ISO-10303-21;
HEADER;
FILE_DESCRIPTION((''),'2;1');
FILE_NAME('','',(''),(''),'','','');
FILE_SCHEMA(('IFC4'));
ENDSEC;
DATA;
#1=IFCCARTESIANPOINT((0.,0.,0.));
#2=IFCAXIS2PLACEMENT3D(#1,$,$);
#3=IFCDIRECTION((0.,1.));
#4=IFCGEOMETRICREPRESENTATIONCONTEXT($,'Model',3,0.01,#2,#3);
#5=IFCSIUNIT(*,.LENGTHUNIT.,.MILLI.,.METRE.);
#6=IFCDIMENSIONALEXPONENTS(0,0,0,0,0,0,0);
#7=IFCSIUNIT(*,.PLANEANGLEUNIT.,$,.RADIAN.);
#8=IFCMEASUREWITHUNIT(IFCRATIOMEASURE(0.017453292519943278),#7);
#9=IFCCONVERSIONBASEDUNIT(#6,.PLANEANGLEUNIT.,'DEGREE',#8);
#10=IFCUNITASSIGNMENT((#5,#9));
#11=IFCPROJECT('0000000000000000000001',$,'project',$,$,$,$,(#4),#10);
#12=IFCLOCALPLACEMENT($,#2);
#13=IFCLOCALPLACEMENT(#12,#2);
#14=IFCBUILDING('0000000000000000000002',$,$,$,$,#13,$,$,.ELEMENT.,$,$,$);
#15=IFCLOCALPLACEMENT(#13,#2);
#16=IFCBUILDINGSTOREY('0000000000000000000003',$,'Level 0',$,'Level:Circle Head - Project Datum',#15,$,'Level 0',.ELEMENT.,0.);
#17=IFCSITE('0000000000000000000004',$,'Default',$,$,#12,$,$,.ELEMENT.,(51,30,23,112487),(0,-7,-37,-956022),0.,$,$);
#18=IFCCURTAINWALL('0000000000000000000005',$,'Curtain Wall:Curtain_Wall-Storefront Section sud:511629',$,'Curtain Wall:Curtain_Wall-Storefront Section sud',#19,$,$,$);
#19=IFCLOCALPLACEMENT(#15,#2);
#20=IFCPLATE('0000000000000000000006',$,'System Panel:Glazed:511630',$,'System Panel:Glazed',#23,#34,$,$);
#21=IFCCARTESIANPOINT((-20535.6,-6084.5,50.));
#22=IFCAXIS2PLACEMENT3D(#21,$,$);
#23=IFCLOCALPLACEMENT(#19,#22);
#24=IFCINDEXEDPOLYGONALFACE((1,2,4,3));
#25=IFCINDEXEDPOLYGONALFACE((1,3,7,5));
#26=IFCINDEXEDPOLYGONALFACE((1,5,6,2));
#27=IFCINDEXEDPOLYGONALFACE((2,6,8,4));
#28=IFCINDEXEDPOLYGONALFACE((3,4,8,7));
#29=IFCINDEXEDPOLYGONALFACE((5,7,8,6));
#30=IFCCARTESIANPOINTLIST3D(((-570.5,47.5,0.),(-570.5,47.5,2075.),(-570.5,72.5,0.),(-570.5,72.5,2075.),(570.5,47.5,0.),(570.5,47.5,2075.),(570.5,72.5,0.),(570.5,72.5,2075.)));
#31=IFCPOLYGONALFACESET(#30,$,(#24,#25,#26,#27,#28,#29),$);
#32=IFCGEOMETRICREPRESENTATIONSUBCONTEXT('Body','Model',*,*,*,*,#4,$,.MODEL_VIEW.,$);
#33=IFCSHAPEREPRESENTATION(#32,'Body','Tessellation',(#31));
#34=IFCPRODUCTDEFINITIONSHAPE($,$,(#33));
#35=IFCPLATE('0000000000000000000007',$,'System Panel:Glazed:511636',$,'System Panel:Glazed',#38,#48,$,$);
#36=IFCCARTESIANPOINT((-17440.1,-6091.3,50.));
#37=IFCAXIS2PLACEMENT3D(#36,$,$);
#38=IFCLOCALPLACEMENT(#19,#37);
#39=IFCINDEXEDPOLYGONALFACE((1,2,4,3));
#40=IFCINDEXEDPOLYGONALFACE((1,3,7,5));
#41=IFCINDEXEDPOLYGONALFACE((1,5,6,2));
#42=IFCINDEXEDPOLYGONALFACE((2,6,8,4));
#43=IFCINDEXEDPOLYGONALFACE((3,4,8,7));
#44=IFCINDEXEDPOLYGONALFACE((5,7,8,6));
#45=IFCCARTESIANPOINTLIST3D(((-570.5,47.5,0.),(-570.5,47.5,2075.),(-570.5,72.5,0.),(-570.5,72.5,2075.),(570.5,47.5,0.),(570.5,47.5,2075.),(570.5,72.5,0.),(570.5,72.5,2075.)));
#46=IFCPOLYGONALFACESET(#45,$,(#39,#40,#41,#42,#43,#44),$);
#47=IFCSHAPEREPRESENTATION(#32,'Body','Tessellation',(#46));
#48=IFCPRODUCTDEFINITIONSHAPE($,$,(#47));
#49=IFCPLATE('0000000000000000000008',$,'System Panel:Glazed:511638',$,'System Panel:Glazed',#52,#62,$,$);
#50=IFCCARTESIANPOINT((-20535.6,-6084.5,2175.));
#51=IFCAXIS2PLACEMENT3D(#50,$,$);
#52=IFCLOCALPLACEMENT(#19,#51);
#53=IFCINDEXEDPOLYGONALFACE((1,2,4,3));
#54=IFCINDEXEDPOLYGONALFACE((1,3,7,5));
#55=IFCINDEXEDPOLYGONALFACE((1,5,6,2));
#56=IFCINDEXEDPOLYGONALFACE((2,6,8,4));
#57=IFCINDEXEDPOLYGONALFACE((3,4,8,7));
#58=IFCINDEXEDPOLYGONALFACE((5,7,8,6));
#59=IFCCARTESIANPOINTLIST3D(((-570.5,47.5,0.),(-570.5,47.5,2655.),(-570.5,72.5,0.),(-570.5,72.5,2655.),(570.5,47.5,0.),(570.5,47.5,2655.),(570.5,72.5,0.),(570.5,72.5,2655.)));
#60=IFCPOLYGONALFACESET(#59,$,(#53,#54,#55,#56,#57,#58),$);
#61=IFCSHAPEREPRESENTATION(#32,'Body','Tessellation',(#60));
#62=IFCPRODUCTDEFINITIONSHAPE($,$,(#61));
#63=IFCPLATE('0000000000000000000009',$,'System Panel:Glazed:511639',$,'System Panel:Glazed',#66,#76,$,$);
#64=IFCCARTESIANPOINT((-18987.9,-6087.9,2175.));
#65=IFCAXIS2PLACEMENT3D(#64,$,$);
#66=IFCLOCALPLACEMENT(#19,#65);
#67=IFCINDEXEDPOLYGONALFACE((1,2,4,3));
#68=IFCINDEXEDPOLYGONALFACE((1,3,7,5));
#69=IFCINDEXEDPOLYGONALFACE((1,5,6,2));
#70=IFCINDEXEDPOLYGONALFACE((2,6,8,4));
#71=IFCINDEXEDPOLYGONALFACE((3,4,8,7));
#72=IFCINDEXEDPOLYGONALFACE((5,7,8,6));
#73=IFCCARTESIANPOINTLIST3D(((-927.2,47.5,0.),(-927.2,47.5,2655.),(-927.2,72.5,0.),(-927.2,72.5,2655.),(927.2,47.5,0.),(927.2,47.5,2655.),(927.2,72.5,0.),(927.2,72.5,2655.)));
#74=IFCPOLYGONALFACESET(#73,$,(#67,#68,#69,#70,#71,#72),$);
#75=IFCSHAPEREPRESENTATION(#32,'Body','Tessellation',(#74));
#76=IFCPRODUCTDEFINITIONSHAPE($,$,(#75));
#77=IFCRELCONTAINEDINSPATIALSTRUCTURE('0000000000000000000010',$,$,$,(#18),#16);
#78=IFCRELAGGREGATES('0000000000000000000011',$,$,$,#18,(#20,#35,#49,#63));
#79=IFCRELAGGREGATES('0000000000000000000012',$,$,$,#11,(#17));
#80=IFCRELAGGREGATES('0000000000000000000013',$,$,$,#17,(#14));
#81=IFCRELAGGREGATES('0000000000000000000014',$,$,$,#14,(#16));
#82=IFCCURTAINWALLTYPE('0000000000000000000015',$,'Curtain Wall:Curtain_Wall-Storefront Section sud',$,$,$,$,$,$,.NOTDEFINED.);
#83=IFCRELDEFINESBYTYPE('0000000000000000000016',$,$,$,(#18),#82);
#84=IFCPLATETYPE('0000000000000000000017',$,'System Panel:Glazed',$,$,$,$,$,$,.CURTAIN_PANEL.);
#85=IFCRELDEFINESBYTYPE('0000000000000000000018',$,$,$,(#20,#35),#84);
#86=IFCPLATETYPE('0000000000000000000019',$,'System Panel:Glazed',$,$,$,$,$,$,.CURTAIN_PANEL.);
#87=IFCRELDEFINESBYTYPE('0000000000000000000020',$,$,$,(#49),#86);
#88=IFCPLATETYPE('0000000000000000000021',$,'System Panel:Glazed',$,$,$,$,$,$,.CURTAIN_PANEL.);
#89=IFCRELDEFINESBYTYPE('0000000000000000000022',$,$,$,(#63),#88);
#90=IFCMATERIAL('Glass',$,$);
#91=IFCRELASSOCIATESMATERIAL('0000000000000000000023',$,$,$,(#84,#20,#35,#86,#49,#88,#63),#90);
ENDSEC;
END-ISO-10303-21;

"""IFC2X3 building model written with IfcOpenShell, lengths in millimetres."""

from ifc_helpers import new_model, entity, si_unit, converted_unit, direction, frame, frame_2d, origin, origin_2d_with_axis, place, context, subcontext, project, spatial, rectangle, extrude, source, transform, mapped, material, type_object, type_shapes, element, aggregate, save


model = new_model("IFC2X3")

# Units and contexts
model_context = context("Model", 3, precision=0.01, world=origin(), true_north=direction((0.0, 1.0)))
body_context = subcontext(model_context, "Body", "Model", "MODEL_VIEW")
ifc_project = project(units=[si_unit("LENGTHUNIT", "METRE", prefix="MILLI"), converted_unit("PLANEANGLEUNIT", "DEGREE", entity("IfcRatioMeasure", 0.017453292519943278), si_unit("PLANEANGLEUNIT", "RADIAN"), dimensions=[0, 0, 0, 0, 0, 0, 0])], contexts=[model_context])

# Site, building, storey
site_placement = place(None, origin())
site = spatial("IfcSite", under=ifc_project, at=site_placement, Name="Default", CompositionType="ELEMENT", RefLatitude=(51, 30, 23, 112487), RefLongitude=(0, -7, -37, -956022), RefElevation=0.0)
building_placement = place(site_placement, origin())
building = spatial("IfcBuilding", under=site, at=building_placement, CompositionType="ELEMENT")
storey_placement = place(building_placement, origin())
storey = spatial("IfcBuildingStorey", under=building, at=storey_placement, Name="Level 0", ObjectType="Level:Circle Head - Project Datum", LongName="Level 0", CompositionType="ELEMENT", Elevation=0.0)

# Curtain wall
curtain_wall_type_1 = type_object("IfcCurtainWallType", Name="Curtain Wall:Curtain_Wall-Storefront Section sud", PredefinedType="NOTDEFINED")
curtain_wall_1_placement = place(storey_placement, origin())
curtain_wall_1 = element("IfcCurtainWall", 1, at=curtain_wall_1_placement, inside=storey, type_object=curtain_wall_type_1, Name="Curtain Wall:Curtain_Wall-Storefront Section sud:511629", ObjectType="Curtain Wall:Curtain_Wall-Storefront Section sud")

# Plates
ifc_material_1 = material(Name="Glass")
plate_type_1 = type_object("IfcPlateType", Name="System Panel:Glazed", PredefinedType="CURTAIN_PANEL", material=ifc_material_1)
shared_shape_1 = source(origin(), body_context, "Body", "SweptSolid", [
    extrude(rectangle(XDim=25.0, YDim=1141.0, at=origin_2d_with_axis()), frame((0.0, 60.0, 0.0), z_axis=(0.0, 0.0, 1.0), x_axis=(0.0, 1.0, 0.0)), (0.0, 0.0, 1.0), 2075.0),
])
type_shapes(plate_type_1, [shared_shape_1])
plate_1_placement = place(curtain_wall_1_placement, frame((-20535.6, -6084.5, 50.0)))
plate_1 = element("IfcPlate", 2, at=plate_1_placement, type_object=plate_type_1, material=ifc_material_1, Name="System Panel:Glazed:511630", ObjectType="System Panel:Glazed", context=body_context, shape_type="MappedRepresentation", body=[
    mapped(shared_shape_1, transform((0.0, 0.0, 0.0), scale=1.0)),
])
plate_2_placement = place(curtain_wall_1_placement, frame((-17440.1, -6091.3, 50.0)))
plate_2 = element("IfcPlate", 3, at=plate_2_placement, type_object=plate_type_1, material=ifc_material_1, Name="System Panel:Glazed:511636", ObjectType="System Panel:Glazed", context=body_context, shape_type="MappedRepresentation", body=[
    mapped(shared_shape_1, transform((0.0, 0.0, 0.0), scale=1.0)),
])
plate_type_2 = type_object("IfcPlateType", Name="System Panel:Glazed", PredefinedType="CURTAIN_PANEL", material=ifc_material_1)
shared_shape_2 = source(origin(), body_context, "Body", "SweptSolid", [
    extrude(rectangle(XDim=25.0, YDim=1141.0, at=frame_2d((0.0, 0.0), x_axis=(1.0, 0.0))), frame((0.0, 60.0, 0.0), z_axis=(0.0, 0.0, 1.0), x_axis=(0.0, 1.0, 0.0)), (0.0, 0.0, 1.0), 2655.0),
])
type_shapes(plate_type_2, [shared_shape_2])
plate_3_placement = place(curtain_wall_1_placement, frame((-20535.6, -6084.5, 2175.0)))
plate_3 = element("IfcPlate", 4, at=plate_3_placement, type_object=plate_type_2, material=ifc_material_1, Name="System Panel:Glazed:511638", ObjectType="System Panel:Glazed", context=body_context, shape_type="MappedRepresentation", body=[
    mapped(shared_shape_2, transform((0.0, 0.0, 0.0), scale=1.0)),
])
plate_type_3 = type_object("IfcPlateType", Name="System Panel:Glazed", PredefinedType="CURTAIN_PANEL", material=ifc_material_1)
shared_shape_3 = source(origin(), body_context, "Body", "SweptSolid", [
    extrude(rectangle(XDim=25.0, YDim=1854.5, at=frame_2d((0.0, 0.0), x_axis=(1.0, 0.0))), frame((0.0, 60.0, 0.0), z_axis=(0.0, 0.0, 1.0), x_axis=(0.0, 1.0, 0.0)), (0.0, 0.0, 1.0), 2655.0),
])
type_shapes(plate_type_3, [shared_shape_3])
plate_4_placement = place(curtain_wall_1_placement, frame((-18987.9, -6087.9, 2175.0)))
plate_4 = element("IfcPlate", 5, at=plate_4_placement, type_object=plate_type_3, material=ifc_material_1, Name="System Panel:Glazed:511639", ObjectType="System Panel:Glazed", context=body_context, shape_type="MappedRepresentation", body=[
    mapped(shared_shape_3, transform((0.0, 0.0, 0.0), scale=1.0)),
])
aggregate(curtain_wall_1, [plate_1, plate_2, plate_3, plate_4])

save(model, "model.ifc")
